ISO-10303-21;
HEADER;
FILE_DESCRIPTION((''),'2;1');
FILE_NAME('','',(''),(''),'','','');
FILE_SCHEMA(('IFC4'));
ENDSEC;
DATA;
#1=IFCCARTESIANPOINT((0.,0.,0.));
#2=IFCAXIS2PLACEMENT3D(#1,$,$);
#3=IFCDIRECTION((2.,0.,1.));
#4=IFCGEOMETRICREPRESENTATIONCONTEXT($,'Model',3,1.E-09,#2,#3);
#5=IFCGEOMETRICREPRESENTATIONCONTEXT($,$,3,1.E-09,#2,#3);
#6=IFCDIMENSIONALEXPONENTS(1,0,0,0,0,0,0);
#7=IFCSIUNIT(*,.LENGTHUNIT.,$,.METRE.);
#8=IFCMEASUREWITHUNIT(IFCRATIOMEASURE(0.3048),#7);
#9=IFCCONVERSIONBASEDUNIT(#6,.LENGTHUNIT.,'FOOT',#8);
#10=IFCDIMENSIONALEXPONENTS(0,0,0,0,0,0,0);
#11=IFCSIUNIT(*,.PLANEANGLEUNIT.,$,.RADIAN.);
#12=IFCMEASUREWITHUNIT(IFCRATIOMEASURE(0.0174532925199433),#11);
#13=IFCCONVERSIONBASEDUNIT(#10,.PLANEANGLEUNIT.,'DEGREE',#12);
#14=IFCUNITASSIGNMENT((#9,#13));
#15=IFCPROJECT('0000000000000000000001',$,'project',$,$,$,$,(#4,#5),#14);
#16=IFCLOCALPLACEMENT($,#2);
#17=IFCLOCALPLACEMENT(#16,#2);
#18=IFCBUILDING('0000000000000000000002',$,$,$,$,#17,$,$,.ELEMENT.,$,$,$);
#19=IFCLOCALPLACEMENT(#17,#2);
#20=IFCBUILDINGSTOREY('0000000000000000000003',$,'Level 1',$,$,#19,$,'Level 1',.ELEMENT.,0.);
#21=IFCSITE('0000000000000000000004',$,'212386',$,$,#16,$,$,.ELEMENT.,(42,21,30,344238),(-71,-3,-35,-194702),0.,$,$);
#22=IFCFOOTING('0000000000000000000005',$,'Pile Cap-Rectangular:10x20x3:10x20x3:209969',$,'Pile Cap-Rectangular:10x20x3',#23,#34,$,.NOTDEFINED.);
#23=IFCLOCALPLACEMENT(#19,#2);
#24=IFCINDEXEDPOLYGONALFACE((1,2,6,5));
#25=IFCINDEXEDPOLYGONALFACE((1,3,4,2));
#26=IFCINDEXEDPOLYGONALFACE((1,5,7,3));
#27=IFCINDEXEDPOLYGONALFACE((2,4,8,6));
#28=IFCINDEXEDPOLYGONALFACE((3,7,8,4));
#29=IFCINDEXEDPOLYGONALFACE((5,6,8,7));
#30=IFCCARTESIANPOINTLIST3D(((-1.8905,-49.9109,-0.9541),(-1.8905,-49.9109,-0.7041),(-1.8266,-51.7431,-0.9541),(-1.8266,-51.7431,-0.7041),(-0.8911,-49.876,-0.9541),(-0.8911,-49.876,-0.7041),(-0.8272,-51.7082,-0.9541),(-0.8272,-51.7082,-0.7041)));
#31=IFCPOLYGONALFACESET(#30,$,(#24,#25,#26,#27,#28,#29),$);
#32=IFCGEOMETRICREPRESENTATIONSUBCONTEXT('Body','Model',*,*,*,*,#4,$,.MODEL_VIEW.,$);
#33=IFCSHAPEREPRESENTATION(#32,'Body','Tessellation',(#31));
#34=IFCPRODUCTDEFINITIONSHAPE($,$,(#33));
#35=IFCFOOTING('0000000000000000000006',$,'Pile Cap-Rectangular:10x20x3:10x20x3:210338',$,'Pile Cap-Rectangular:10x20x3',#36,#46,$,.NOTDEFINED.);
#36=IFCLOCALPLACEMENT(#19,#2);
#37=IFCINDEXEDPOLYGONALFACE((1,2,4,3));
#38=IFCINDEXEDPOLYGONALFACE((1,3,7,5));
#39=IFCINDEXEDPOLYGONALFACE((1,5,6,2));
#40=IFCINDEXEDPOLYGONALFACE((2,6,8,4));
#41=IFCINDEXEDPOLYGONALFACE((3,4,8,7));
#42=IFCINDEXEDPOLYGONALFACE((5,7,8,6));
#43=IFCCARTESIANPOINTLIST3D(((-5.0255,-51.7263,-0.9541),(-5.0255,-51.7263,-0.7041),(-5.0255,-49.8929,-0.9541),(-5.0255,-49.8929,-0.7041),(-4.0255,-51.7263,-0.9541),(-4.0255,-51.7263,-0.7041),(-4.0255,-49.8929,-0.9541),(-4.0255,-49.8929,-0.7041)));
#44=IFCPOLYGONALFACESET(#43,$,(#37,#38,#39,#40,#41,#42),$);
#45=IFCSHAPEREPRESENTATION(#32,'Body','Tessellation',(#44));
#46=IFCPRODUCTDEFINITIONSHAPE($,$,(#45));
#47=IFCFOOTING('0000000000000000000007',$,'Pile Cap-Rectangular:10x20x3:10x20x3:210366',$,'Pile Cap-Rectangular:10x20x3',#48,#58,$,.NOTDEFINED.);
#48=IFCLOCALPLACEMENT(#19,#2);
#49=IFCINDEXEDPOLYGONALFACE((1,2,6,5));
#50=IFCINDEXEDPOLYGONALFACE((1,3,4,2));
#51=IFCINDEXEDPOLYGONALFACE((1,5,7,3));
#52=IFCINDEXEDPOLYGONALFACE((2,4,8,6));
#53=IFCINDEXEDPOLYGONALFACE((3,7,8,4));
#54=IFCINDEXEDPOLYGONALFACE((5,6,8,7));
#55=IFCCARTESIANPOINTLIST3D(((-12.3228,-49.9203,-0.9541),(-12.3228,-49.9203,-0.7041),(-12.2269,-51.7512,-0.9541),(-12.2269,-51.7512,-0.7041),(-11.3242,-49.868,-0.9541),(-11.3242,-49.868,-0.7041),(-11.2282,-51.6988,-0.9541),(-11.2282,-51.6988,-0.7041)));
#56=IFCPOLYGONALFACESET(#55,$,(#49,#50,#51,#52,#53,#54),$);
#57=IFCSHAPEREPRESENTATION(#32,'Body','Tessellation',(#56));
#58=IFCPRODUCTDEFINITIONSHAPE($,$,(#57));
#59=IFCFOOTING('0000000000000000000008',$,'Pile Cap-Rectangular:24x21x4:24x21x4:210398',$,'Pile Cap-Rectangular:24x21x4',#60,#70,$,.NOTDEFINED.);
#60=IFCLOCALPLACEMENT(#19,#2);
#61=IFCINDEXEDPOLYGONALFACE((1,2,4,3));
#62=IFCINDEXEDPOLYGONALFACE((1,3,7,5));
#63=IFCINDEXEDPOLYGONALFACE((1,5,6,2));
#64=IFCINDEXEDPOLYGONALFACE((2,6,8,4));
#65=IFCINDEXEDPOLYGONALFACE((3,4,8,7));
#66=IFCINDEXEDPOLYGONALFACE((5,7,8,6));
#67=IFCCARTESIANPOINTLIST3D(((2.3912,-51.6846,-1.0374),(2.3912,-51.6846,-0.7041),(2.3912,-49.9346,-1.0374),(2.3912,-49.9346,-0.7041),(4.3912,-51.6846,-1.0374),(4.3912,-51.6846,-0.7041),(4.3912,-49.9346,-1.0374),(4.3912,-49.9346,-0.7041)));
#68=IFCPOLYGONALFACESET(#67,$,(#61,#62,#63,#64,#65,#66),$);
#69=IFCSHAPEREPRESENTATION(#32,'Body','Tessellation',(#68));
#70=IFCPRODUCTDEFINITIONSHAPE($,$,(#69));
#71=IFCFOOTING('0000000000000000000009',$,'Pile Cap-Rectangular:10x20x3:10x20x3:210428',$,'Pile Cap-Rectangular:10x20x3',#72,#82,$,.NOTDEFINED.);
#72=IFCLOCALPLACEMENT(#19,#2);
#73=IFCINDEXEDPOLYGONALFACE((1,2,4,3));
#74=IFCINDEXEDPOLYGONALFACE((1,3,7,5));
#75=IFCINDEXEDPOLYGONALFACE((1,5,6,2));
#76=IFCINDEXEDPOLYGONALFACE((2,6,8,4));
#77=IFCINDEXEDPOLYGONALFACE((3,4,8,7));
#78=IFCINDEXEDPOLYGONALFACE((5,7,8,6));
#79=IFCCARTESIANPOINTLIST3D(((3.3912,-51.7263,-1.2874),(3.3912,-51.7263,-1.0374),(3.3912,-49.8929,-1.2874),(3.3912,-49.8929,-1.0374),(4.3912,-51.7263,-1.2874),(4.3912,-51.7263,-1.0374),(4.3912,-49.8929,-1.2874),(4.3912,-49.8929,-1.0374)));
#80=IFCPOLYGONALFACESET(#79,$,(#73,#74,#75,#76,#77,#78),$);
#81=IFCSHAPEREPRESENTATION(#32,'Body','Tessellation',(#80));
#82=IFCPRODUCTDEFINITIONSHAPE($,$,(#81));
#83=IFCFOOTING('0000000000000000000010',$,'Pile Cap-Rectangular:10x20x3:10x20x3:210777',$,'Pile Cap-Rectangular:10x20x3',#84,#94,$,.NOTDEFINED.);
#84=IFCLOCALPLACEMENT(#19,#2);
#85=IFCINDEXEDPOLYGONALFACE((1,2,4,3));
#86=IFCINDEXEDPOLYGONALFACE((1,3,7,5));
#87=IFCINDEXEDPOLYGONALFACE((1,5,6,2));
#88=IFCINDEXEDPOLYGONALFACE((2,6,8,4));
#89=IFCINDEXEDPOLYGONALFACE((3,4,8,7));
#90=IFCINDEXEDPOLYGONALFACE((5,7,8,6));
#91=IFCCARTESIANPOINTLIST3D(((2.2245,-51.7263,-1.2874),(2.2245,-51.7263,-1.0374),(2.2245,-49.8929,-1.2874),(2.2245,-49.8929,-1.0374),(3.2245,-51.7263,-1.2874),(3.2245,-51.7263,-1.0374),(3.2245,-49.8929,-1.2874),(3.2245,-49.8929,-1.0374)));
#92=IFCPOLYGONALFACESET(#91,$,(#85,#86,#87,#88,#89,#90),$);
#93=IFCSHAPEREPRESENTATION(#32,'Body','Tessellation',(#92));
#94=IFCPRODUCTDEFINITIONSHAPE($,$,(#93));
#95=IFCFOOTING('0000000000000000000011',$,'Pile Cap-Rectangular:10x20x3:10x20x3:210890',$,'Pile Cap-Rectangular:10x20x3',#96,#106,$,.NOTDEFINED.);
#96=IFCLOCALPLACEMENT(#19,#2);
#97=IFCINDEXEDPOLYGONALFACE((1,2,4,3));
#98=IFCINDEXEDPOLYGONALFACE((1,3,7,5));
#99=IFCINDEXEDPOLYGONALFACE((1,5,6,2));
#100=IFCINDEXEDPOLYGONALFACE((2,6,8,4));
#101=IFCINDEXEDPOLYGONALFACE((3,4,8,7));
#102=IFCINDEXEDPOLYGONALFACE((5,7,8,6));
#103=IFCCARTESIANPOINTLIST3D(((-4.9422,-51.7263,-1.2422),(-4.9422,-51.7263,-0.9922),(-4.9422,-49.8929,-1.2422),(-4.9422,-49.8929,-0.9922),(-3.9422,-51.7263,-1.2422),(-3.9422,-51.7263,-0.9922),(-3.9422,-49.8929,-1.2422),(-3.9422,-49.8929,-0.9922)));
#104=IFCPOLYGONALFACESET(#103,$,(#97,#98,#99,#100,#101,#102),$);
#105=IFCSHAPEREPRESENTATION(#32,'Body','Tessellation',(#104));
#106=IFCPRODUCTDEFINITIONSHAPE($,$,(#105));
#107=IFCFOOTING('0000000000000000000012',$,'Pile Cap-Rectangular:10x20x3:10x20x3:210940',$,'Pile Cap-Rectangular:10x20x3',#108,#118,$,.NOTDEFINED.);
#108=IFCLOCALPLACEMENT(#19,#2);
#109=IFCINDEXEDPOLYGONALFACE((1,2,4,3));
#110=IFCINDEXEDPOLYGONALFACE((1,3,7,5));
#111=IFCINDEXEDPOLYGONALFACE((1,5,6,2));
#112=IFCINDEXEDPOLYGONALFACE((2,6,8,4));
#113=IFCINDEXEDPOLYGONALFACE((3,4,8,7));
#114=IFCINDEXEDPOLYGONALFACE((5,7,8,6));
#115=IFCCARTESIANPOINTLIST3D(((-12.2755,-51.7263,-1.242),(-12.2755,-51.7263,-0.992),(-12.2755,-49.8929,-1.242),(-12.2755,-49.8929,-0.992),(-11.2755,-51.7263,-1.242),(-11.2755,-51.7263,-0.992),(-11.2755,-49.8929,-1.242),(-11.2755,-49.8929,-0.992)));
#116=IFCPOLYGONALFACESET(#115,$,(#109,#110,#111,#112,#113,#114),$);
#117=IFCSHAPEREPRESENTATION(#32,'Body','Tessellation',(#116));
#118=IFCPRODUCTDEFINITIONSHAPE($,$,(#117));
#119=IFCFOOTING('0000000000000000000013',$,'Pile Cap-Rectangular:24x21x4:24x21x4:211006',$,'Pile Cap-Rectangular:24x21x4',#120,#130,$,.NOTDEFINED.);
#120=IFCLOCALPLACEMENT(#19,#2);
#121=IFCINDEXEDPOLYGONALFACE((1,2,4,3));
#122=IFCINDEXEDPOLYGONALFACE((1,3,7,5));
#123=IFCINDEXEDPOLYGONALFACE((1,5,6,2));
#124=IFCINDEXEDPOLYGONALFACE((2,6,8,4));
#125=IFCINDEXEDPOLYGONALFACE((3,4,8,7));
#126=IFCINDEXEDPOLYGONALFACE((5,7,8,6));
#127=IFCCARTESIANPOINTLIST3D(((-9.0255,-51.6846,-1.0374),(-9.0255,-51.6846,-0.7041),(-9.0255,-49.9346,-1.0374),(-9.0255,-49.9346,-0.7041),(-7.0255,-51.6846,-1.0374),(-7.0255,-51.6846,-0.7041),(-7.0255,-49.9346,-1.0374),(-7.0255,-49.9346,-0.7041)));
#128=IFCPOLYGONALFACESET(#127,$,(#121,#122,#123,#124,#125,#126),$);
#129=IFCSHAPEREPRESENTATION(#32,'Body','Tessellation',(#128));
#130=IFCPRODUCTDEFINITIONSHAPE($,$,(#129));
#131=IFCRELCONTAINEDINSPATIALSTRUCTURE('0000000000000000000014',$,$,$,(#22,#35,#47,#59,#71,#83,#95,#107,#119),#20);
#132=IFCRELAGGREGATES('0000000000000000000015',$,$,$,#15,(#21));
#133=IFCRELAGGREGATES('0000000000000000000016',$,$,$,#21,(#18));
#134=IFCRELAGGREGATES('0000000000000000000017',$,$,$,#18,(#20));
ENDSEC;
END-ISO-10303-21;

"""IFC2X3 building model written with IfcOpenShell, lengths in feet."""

from ifc_helpers import new_model, entity, si_unit, converted_unit, direction, frame, frame_2d, origin, origin_2d_with_axis, place, context, subcontext, project, spatial, rectangle, extrude, element, save


model = new_model("IFC2X3")

# Units and contexts
model_context = context("Model", 3, precision=1e-09, world=origin(), true_north=direction((2.0, 0.0, 1.0)))
context_of_model = context(None, 3, precision=1e-09, world=origin(), true_north=direction((2.0, 0.0, 1.0)))
body_context = subcontext(model_context, "Body", "Model", "MODEL_VIEW")
ifc_project = project(units=[converted_unit("LENGTHUNIT", "FOOT", entity("IfcRatioMeasure", 0.3048), si_unit("LENGTHUNIT", "METRE"), dimensions=[1, 0, 0, 0, 0, 0, 0]), converted_unit("PLANEANGLEUNIT", "DEGREE", entity("IfcRatioMeasure", 0.0174532925199433), si_unit("PLANEANGLEUNIT", "RADIAN"), dimensions=[0, 0, 0, 0, 0, 0, 0])], contexts=[model_context, context_of_model])

# Site, building, storey
site_placement = place(None, origin())
site = spatial("IfcSite", under=ifc_project, at=site_placement, Name="212386", CompositionType="ELEMENT", RefLatitude=(42, 21, 30, 344238), RefLongitude=(-71, -3, -35, -194702), RefElevation=0.0)
building_placement = place(site_placement, origin())
building = spatial("IfcBuilding", under=site, at=building_placement, CompositionType="ELEMENT")
storey_placement = place(building_placement, origin())
storey = spatial("IfcBuildingStorey", under=building, at=storey_placement, Name="Level 1", LongName="Level 1", CompositionType="ELEMENT", Elevation=0.0)

# Footings
footing_1_placement = place(storey_placement, origin())
element("IfcFooting", 1, at=footing_1_placement, inside=storey, Name="Pile Cap-Rectangular:10x20x3:10x20x3:209969", ObjectType="Pile Cap-Rectangular:10x20x3", PredefinedType="NOTDEFINED", context=body_context, shape_type="SweptSolid", body=[
    extrude(rectangle(XDim=1.0, YDim=1.8333, at=frame_2d((0.0, 0.0), x_axis=(1.0, 0.0))), frame((-1.3588, -50.8096, -0.9541), z_axis=(0.0, 0.0, 1.0), x_axis=(-0.999391, -0.034899, 0.0)), (0.0, 0.0, 1.0), 0.25),
])
footing_2_placement = place(storey_placement, origin())
element("IfcFooting", 2, at=footing_2_placement, inside=storey, Name="Pile Cap-Rectangular:10x20x3:10x20x3:210338", ObjectType="Pile Cap-Rectangular:10x20x3", PredefinedType="NOTDEFINED", context=body_context, shape_type="SweptSolid", body=[
    extrude(rectangle(XDim=1.0, YDim=1.8333, at=frame_2d((0.0, 0.0), x_axis=(1.0, 0.0))), frame((-4.5255, -50.8096, -0.9541), z_axis=(0.0, 0.0, 1.0), x_axis=(-1.0, 0.0, 0.0)), (0.0, 0.0, 1.0), 0.25),
])
footing_3_placement = place(storey_placement, origin())
element("IfcFooting", 3, at=footing_3_placement, inside=storey, Name="Pile Cap-Rectangular:10x20x3:10x20x3:210366", ObjectType="Pile Cap-Rectangular:10x20x3", PredefinedType="NOTDEFINED", context=body_context, shape_type="SweptSolid", body=[
    extrude(rectangle(XDim=1.0, YDim=1.8333, at=frame_2d((0.0, 0.0), x_axis=(1.0, 0.0))), frame((-11.7755, -50.8096, -0.9541), z_axis=(0.0, 0.0, 1.0), x_axis=(-0.99863, -0.052336, 0.0)), (0.0, 0.0, 1.0), 0.25),
])
footing_4_placement = place(storey_placement, origin())
element("IfcFooting", 4, at=footing_4_placement, inside=storey, Name="Pile Cap-Rectangular:24x21x4:24x21x4:210398", ObjectType="Pile Cap-Rectangular:24x21x4", PredefinedType="NOTDEFINED", context=body_context, shape_type="SweptSolid", body=[
    extrude(rectangle(XDim=2.0, YDim=1.75, at=origin_2d_with_axis()), frame((3.3912, -50.8096, -1.0374), z_axis=(0.0, 0.0, 1.0), x_axis=(-1.0, 0.0, 0.0)), (0.0, 0.0, 1.0), 0.3333),
])
footing_5_placement = place(storey_placement, origin())
element("IfcFooting", 5, at=footing_5_placement, inside=storey, Name="Pile Cap-Rectangular:10x20x3:10x20x3:210428", ObjectType="Pile Cap-Rectangular:10x20x3", PredefinedType="NOTDEFINED", context=body_context, shape_type="SweptSolid", body=[
    extrude(rectangle(XDim=1.0, YDim=1.8333, at=frame_2d((0.0, 0.0), x_axis=(1.0, 0.0))), frame((3.8912, -50.8096, -1.2874), z_axis=(0.0, 0.0, 1.0), x_axis=(-1.0, 0.0, 0.0)), (0.0, 0.0, 1.0), 0.25),
])
footing_6_placement = place(storey_placement, origin())
element("IfcFooting", 6, at=footing_6_placement, inside=storey, Name="Pile Cap-Rectangular:10x20x3:10x20x3:210777", ObjectType="Pile Cap-Rectangular:10x20x3", PredefinedType="NOTDEFINED", context=body_context, shape_type="SweptSolid", body=[
    extrude(rectangle(XDim=1.0, YDim=1.8333, at=frame_2d((0.0, 0.0), x_axis=(1.0, 0.0))), frame((2.7245, -50.8096, -1.2874), z_axis=(0.0, 0.0, 1.0), x_axis=(-1.0, 0.0, 0.0)), (0.0, 0.0, 1.0), 0.25),
])
footing_7_placement = place(storey_placement, origin())
element("IfcFooting", 7, at=footing_7_placement, inside=storey, Name="Pile Cap-Rectangular:10x20x3:10x20x3:210890", ObjectType="Pile Cap-Rectangular:10x20x3", PredefinedType="NOTDEFINED", context=body_context, shape_type="SweptSolid", body=[
    extrude(rectangle(XDim=1.0, YDim=1.8333, at=frame_2d((0.0, 0.0), x_axis=(1.0, 0.0))), frame((-4.4422, -50.8096, -1.2422), z_axis=(0.0, 0.0, 1.0), x_axis=(-1.0, 0.0, 0.0)), (0.0, 0.0, 1.0), 0.25),
])
footing_8_placement = place(storey_placement, origin())
element("IfcFooting", 8, at=footing_8_placement, inside=storey, Name="Pile Cap-Rectangular:10x20x3:10x20x3:210940", ObjectType="Pile Cap-Rectangular:10x20x3", PredefinedType="NOTDEFINED", context=body_context, shape_type="SweptSolid", body=[
    extrude(rectangle(XDim=1.0, YDim=1.8333, at=frame_2d((0.0, 0.0), x_axis=(1.0, 0.0))), frame((-11.7755, -50.8096, -1.242), z_axis=(0.0, 0.0, 1.0), x_axis=(-1.0, 0.0, 0.0)), (0.0, 0.0, 1.0), 0.25),
])
footing_9_placement = place(storey_placement, origin())
element("IfcFooting", 9, at=footing_9_placement, inside=storey, Name="Pile Cap-Rectangular:24x21x4:24x21x4:211006", ObjectType="Pile Cap-Rectangular:24x21x4", PredefinedType="NOTDEFINED", context=body_context, shape_type="SweptSolid", body=[
    extrude(rectangle(XDim=2.0, YDim=1.75, at=origin_2d_with_axis()), frame((-8.0255, -50.8096, -1.0374), z_axis=(0.0, 0.0, 1.0), x_axis=(-1.0, 0.0, 0.0)), (0.0, 0.0, 1.0), 0.3333),
])

save(model, "model.ifc")
